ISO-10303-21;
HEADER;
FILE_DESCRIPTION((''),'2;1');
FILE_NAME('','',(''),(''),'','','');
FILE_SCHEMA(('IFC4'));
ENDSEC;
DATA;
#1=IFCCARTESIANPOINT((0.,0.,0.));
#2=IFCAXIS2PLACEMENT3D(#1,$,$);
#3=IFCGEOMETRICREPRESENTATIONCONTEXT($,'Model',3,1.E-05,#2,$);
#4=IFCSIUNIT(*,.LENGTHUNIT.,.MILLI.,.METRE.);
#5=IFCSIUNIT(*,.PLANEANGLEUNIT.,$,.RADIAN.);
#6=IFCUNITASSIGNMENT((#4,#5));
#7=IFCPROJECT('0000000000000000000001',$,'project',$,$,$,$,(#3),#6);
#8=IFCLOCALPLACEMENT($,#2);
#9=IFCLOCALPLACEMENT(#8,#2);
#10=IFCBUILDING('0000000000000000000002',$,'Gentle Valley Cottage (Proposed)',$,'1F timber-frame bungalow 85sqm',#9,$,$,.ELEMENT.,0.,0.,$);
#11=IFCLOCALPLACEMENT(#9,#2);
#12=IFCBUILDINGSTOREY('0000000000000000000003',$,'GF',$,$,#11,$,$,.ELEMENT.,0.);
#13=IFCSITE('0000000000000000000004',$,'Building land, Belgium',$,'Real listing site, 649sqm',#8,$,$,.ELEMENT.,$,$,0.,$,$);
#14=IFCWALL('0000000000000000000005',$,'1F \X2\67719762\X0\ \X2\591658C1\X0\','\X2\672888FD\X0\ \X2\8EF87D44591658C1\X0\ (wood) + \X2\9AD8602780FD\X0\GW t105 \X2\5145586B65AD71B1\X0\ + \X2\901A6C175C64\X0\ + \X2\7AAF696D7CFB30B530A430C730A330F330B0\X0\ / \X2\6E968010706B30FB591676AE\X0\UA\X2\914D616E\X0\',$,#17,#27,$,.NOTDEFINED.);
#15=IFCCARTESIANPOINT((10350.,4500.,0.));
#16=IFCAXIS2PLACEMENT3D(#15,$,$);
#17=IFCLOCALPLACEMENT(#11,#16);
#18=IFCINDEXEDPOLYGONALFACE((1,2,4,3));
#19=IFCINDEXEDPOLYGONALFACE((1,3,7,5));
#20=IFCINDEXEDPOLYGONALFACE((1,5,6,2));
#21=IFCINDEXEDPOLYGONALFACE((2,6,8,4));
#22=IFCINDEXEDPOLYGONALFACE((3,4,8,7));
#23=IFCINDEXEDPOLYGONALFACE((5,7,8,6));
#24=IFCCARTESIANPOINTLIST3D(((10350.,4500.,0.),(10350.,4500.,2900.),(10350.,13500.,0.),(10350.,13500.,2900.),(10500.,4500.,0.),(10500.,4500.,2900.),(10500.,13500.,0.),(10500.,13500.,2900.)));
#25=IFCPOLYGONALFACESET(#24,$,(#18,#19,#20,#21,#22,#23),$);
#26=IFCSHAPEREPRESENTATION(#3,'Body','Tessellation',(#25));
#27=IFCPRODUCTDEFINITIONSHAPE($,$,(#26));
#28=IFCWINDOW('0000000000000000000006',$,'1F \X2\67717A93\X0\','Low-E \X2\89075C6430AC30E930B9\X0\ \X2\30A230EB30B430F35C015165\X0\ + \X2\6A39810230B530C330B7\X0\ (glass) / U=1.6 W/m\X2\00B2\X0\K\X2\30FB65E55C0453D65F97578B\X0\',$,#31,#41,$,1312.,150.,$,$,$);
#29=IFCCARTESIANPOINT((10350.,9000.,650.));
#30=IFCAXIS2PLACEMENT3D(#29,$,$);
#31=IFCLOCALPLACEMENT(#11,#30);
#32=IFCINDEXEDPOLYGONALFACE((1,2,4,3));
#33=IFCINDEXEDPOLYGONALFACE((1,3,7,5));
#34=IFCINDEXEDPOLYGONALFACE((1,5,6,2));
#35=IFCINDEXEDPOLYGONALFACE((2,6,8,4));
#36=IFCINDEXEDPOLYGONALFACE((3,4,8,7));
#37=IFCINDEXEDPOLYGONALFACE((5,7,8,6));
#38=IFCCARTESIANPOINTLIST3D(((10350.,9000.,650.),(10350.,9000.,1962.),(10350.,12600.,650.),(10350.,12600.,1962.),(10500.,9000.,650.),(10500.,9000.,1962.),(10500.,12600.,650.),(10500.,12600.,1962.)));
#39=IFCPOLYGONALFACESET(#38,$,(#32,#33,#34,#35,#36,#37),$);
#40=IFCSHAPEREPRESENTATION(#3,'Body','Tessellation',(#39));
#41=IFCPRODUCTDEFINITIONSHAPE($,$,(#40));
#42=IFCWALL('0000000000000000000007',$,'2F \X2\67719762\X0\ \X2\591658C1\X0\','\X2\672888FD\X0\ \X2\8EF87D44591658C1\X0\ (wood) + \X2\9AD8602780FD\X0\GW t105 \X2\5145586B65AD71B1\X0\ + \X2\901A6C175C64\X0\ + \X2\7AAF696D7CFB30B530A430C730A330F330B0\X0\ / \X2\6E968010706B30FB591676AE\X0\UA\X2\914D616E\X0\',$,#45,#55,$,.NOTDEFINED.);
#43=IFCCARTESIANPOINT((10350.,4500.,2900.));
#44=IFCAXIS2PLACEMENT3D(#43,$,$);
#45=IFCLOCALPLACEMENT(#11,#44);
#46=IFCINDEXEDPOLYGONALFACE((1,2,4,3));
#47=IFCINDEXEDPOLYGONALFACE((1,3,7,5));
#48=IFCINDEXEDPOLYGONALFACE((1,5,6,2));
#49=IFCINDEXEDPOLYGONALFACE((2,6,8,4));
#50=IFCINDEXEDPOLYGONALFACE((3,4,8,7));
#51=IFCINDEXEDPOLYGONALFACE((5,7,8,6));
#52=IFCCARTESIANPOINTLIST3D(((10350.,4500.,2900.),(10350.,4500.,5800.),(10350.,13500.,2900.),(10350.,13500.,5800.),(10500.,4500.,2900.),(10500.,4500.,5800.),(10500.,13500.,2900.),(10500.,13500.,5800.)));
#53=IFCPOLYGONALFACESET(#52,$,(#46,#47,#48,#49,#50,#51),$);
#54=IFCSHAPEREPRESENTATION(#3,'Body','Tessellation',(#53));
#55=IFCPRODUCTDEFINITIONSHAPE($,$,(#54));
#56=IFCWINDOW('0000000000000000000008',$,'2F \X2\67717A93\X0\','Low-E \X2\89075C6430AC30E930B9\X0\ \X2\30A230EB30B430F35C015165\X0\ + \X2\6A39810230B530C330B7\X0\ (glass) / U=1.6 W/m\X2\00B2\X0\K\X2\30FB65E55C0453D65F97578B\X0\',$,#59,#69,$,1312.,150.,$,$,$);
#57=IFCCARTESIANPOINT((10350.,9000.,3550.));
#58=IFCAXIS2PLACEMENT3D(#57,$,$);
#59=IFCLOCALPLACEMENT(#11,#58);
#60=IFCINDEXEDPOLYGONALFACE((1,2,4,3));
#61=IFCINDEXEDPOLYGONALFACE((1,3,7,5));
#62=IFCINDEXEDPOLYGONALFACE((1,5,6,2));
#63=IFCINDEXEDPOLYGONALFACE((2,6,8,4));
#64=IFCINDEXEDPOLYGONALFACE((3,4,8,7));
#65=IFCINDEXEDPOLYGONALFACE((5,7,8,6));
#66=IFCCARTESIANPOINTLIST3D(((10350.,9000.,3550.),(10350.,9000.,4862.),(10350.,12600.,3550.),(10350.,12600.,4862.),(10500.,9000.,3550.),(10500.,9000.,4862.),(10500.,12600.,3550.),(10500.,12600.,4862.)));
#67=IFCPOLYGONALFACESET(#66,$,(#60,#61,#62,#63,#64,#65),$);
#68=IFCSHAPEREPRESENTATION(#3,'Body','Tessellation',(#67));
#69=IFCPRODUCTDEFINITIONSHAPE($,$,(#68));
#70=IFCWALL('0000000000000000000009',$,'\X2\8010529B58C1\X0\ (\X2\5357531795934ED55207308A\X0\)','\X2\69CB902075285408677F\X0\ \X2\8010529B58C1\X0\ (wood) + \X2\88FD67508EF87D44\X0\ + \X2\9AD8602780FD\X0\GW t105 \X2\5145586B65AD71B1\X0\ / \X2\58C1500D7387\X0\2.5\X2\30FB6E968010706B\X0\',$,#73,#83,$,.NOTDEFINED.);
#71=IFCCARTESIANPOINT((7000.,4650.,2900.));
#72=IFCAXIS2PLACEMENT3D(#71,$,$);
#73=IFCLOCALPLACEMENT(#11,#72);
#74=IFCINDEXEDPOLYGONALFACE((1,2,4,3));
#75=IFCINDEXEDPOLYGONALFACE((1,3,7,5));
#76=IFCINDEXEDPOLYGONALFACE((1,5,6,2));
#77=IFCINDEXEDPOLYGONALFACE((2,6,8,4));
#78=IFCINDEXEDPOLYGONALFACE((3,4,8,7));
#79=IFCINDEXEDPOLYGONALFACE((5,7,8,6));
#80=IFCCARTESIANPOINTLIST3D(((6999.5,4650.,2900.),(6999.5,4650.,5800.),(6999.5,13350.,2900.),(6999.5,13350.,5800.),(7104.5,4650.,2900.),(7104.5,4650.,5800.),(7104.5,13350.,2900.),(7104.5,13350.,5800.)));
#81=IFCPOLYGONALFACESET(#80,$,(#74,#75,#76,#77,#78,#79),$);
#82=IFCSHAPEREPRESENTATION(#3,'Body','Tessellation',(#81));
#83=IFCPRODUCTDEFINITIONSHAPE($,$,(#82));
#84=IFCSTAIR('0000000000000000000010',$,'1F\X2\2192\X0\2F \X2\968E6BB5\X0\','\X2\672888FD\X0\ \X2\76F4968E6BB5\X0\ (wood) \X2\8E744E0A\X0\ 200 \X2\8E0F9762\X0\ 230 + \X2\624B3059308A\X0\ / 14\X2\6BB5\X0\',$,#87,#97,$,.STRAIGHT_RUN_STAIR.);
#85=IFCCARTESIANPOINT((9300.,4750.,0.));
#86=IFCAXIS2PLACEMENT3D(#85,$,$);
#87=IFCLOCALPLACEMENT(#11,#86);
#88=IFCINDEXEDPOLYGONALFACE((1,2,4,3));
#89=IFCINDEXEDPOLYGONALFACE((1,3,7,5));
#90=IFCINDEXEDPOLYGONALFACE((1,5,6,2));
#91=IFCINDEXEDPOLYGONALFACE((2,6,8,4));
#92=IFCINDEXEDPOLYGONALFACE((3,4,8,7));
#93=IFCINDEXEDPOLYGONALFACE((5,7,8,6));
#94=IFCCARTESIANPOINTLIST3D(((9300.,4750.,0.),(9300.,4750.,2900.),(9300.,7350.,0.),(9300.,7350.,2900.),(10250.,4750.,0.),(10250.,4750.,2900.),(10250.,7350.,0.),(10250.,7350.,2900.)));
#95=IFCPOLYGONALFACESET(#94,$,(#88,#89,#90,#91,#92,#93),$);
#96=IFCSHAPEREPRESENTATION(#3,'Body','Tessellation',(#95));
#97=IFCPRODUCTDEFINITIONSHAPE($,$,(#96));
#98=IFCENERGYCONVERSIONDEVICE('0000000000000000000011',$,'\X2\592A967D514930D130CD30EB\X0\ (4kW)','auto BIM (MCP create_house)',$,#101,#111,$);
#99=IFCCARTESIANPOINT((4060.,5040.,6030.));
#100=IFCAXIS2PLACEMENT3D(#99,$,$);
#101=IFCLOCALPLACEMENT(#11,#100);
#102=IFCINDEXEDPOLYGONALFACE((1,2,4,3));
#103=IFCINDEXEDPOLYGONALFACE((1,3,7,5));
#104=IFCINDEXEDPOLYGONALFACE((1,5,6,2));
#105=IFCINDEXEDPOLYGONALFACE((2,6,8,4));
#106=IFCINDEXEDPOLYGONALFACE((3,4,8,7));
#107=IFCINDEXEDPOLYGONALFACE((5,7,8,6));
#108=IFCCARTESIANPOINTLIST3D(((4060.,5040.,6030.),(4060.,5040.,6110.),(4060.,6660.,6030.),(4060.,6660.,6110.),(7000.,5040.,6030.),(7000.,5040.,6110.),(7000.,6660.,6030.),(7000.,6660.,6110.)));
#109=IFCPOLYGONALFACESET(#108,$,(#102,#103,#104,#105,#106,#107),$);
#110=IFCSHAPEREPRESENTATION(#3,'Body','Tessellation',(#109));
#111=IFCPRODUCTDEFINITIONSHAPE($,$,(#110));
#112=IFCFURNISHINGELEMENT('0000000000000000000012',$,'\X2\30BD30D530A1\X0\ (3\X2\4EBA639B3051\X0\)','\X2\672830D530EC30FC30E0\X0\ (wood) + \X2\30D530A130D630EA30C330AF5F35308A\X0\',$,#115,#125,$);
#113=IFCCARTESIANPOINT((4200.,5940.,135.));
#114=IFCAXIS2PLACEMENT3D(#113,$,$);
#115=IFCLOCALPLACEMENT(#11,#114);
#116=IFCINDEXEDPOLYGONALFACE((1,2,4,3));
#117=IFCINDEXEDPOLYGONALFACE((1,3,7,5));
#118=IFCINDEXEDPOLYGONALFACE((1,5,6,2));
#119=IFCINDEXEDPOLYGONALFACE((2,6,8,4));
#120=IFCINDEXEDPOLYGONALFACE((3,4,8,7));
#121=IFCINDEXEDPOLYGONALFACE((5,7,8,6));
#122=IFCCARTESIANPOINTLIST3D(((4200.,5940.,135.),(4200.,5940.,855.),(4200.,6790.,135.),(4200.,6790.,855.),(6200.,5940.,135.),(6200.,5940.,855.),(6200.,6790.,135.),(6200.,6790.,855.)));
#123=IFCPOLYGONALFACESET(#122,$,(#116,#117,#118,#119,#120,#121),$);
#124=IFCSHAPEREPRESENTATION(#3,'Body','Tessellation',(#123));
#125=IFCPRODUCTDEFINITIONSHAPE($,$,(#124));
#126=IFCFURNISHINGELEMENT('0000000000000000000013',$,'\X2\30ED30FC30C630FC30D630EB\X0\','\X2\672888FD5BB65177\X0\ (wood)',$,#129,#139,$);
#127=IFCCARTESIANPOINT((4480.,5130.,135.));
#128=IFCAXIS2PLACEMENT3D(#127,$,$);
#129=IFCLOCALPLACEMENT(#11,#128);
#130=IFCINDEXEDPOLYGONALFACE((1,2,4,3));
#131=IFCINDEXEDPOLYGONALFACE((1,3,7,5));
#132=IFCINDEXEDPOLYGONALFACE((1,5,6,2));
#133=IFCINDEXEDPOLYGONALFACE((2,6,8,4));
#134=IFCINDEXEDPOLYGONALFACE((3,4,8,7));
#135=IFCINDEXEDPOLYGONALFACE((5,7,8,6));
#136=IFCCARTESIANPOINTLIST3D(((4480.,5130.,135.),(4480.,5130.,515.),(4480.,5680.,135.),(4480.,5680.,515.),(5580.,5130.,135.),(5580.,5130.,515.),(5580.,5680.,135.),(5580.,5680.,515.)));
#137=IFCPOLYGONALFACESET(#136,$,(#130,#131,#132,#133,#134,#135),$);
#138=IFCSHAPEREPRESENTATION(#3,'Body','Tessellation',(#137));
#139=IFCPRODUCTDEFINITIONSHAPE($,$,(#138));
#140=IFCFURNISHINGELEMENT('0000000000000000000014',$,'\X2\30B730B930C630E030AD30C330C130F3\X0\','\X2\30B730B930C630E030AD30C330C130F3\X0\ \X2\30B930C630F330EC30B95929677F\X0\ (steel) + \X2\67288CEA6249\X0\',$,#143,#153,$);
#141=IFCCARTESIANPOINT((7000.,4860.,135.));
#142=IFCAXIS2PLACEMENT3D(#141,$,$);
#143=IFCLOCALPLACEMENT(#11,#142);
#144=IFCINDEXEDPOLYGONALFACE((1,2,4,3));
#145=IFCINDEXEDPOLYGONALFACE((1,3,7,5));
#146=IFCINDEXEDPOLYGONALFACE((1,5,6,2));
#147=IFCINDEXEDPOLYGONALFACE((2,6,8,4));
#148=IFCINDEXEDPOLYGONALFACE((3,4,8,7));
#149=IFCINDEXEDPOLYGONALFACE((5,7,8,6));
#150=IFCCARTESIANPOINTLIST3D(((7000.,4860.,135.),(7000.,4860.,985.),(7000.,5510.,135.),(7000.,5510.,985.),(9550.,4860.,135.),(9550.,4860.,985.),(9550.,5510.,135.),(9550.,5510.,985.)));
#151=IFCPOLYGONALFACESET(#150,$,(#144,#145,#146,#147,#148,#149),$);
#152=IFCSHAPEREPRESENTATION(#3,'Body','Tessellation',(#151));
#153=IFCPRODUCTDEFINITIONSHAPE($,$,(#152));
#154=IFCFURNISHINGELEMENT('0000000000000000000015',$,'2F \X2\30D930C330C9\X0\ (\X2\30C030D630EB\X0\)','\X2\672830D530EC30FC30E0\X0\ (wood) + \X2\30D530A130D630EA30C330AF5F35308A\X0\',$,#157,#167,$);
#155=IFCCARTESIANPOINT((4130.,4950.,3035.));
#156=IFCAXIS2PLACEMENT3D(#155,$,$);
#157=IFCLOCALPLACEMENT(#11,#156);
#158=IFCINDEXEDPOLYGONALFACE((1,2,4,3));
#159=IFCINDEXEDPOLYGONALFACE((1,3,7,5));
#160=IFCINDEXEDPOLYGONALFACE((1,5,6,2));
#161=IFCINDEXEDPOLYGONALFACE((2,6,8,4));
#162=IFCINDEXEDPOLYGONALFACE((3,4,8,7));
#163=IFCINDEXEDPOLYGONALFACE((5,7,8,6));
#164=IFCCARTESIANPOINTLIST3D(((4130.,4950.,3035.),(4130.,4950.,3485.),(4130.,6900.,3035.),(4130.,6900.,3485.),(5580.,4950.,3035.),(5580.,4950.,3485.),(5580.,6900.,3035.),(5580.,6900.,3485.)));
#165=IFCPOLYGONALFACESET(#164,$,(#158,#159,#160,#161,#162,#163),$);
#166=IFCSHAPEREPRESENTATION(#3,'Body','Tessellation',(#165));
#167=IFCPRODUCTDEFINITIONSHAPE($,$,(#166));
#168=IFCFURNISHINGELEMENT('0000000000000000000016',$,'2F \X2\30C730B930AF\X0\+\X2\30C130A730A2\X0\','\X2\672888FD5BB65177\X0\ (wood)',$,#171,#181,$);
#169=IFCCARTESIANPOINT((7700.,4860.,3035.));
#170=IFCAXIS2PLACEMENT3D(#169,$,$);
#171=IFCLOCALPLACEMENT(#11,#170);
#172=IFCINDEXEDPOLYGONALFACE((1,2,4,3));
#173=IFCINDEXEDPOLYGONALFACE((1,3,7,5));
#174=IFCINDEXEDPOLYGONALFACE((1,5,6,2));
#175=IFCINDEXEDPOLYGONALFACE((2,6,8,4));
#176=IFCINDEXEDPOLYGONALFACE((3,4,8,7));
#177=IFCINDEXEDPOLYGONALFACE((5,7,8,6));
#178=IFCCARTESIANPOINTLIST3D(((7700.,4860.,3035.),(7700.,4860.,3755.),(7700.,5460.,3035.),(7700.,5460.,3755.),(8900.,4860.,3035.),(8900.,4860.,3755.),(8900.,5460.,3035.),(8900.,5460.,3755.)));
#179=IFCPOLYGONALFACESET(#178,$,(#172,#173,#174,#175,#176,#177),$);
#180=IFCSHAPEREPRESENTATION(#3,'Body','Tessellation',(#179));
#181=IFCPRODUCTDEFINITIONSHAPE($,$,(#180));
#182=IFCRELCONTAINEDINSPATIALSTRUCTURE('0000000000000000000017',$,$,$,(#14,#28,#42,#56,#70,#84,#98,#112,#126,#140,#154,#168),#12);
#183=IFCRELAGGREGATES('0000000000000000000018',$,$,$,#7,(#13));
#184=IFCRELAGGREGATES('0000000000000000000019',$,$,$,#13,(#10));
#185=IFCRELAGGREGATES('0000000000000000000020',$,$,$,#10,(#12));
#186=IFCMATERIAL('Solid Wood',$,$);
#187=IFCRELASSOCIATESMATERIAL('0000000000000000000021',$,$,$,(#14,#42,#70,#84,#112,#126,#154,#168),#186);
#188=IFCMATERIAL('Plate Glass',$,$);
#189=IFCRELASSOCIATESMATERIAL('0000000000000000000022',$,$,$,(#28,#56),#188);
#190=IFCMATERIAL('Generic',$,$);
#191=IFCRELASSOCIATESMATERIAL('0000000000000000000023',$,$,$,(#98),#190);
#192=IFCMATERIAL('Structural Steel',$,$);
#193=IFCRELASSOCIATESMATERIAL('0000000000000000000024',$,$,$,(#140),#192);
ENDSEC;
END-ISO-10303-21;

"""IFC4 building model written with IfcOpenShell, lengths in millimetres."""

from ifc_helpers import new_model, si_unit, frame, frame_2d, origin, place, context, project, spatial, rectangle, extrude, material, element, fill, save


model = new_model("IFC4")

# Units and contexts
model_context = context("Model", 3, precision=1e-05, world=origin())
ifc_project = project(units=[si_unit("LENGTHUNIT", "METRE", prefix="MILLI"), si_unit("PLANEANGLEUNIT", "RADIAN")], contexts=[model_context])

# Site, building, storey
site_placement = place(None, origin())
site = spatial("IfcSite", under=ifc_project, at=site_placement, Name="Building land, Belgium", ObjectType="Real listing site, 649sqm", CompositionType="ELEMENT", RefElevation=0.0)
building_placement = place(site_placement, origin())
building = spatial("IfcBuilding", under=site, at=building_placement, Name="Gentle Valley Cottage (Proposed)", ObjectType="1F timber-frame bungalow 85sqm", CompositionType="ELEMENT", ElevationOfRefHeight=0.0, ElevationOfTerrain=0.0)
storey_placement = place(building_placement, origin())
storey = spatial("IfcBuildingStorey", under=building, at=storey_placement, Name="GF", CompositionType="ELEMENT", Elevation=0.0)

# Wall, opening, window
ifc_material_1 = material(Name="Solid Wood")
wall_1_placement = place(storey_placement, frame((10350.0, 4500.0, 0.0)))
wall_1 = element("IfcWall", 1, at=wall_1_placement, inside=storey, material=ifc_material_1, Name="1F 東面 外壁", Description="木製 軸組外壁 (wood) + 高性能GW t105 充填断熱 + 通気層 + 窯業系サイディング / 準耐火・外皮UA配慮", PredefinedType="NOTDEFINED", context=model_context, shape_type="SweptSolid", body=[
    extrude(rectangle(XDim=150.0, YDim=9000.0, at=frame_2d((75.0, 4500.0))), frame((10350.0, 4500.0, 0.0)), (0.0, 0.0, 1.0), 2900.0),
])
opening_1_placement = place(storey_placement, frame((10350.0, 9000.0, 650.0)))
opening_1 = element("IfcOpeningElement", 2, at=opening_1_placement, cuts=wall_1, PredefinedType="NOTDEFINED", context=model_context, shape_type="SweptSolid", body=[
    extrude(rectangle(XDim=150.0, YDim=3600.0, at=frame_2d((75.0, 1800.0))), frame((10350.0, 9000.0, 650.0)), (0.0, 0.0, 1.0), 1312.0),
])
ifc_material_2 = material(Name="Plate Glass")
window_1_placement = place(storey_placement, frame((10350.0, 9000.0, 650.0)))
window_1 = element("IfcWindow", 3, at=window_1_placement, inside=storey, material=ifc_material_2, Name="1F 東窓", Description="Low-E 複層ガラス アルゴン封入 + 樹脂サッシ (glass) / U=1.6 W/m²K・日射取得型", OverallHeight=1312.0, OverallWidth=150.0, context=model_context, shape_type="SweptSolid", body=[
    extrude(rectangle(XDim=150.0, YDim=3600.0, at=frame_2d((75.0, 1800.0))), frame((10350.0, 9000.0, 650.0)), (0.0, 0.0, 1.0), 1312.0),
])
fill(opening_1, window_1)

# Wall, opening, window
wall_2_placement = place(storey_placement, frame((10350.0, 4500.0, 2900.0)))
wall_2 = element("IfcWall", 4, at=wall_2_placement, inside=storey, material=ifc_material_1, Name="2F 東面 外壁", Description="木製 軸組外壁 (wood) + 高性能GW t105 充填断熱 + 通気層 + 窯業系サイディング / 準耐火・外皮UA配慮", PredefinedType="NOTDEFINED", context=model_context, shape_type="SweptSolid", body=[
    extrude(rectangle(XDim=150.0, YDim=9000.0, at=frame_2d((75.0, 4500.0))), frame((10350.0, 4500.0, 2900.0)), (0.0, 0.0, 1.0), 2900.0),
])
opening_2_placement = place(storey_placement, frame((10350.0, 9000.0, 3550.0)))
opening_2 = element("IfcOpeningElement", 5, at=opening_2_placement, cuts=wall_2, PredefinedType="NOTDEFINED", context=model_context, shape_type="SweptSolid", body=[
    extrude(rectangle(XDim=150.0, YDim=3600.0, at=frame_2d((75.0, 1800.0))), frame((10350.0, 9000.0, 3550.0)), (0.0, 0.0, 1.0), 1312.0),
])
window_2_placement = place(storey_placement, frame((10350.0, 9000.0, 3550.0)))
window_2 = element("IfcWindow", 6, at=window_2_placement, inside=storey, material=ifc_material_2, Name="2F 東窓", Description="Low-E 複層ガラス アルゴン封入 + 樹脂サッシ (glass) / U=1.6 W/m²K・日射取得型", OverallHeight=1312.0, OverallWidth=150.0, context=model_context, shape_type="SweptSolid", body=[
    extrude(rectangle(XDim=150.0, YDim=3600.0, at=frame_2d((75.0, 1800.0))), frame((10350.0, 9000.0, 3550.0)), (0.0, 0.0, 1.0), 1312.0),
])
fill(opening_2, window_2)

# Wall
wall_3_placement = place(storey_placement, frame((7000.0, 4650.0, 2900.0)))
element("IfcWall", 7, at=wall_3_placement, inside=storey, material=ifc_material_1, Name="耐力壁 (南北間仕切り)", Description="構造用合板 耐力壁 (wood) + 製材軸組 + 高性能GW t105 充填断熱 / 壁倍率2.5・準耐火", PredefinedType="NOTDEFINED", context=model_context, shape_type="SweptSolid", body=[
    extrude(rectangle(XDim=105.0, YDim=8700.0, at=frame_2d((52.0, 4350.0))), frame((7000.0, 4650.0, 2900.0)), (0.0, 0.0, 1.0), 2900.0),
])

# Stair
stair_placement = place(storey_placement, frame((9300.0, 4750.0, 0.0)))
element("IfcStair", 8, at=stair_placement, inside=storey, material=ifc_material_1, Name="1F→2F 階段", Description="木製 直階段 (wood) 蹴上 200 踏面 230 + 手すり / 14段", PredefinedType="STRAIGHT_RUN_STAIR", context=model_context, shape_type="SweptSolid", body=[
    extrude(rectangle(XDim=950.0, YDim=2600.0, at=frame_2d((475.0, 1300.0))), frame((9300.0, 4750.0, 0.0)), (0.0, 0.0, 1.0), 2900.0),
])

# Energy conversion device
ifc_material_3 = material(Name="Generic")
energy_conversion_device_placement = place(storey_placement, frame((4060.0, 5040.0, 6030.0)))
element("IfcEnergyConversionDevice", 9, at=energy_conversion_device_placement, inside=storey, material=ifc_material_3, Name="太陽光パネル (4kW)", Description="auto BIM (MCP create_house)", context=model_context, shape_type="SweptSolid", body=[
    extrude(rectangle(XDim=2940.0, YDim=1620.0, at=frame_2d((1470.0, 810.0))), frame((4060.0, 5040.0, 6030.0)), (0.0, 0.0, 1.0), 80.0),
])

# Furnishing elements
furnishing_1_placement = place(storey_placement, frame((4200.0, 5940.0, 135.0)))
element("IfcFurnishingElement", 10, at=furnishing_1_placement, inside=storey, material=ifc_material_1, Name="ソファ (3人掛け)", Description="木フレーム (wood) + ファブリック張り", context=model_context, shape_type="SweptSolid", body=[
    extrude(rectangle(XDim=2000.0, YDim=850.0, at=frame_2d((1000.0, 425.0))), frame((4200.0, 5940.0, 135.0)), (0.0, 0.0, 1.0), 720.0),
])
furnishing_2_placement = place(storey_placement, frame((4480.0, 5130.0, 135.0)))
element("IfcFurnishingElement", 11, at=furnishing_2_placement, inside=storey, material=ifc_material_1, Name="ローテーブル", Description="木製家具 (wood)", context=model_context, shape_type="SweptSolid", body=[
    extrude(rectangle(XDim=1100.0, YDim=550.0, at=frame_2d((550.0, 275.0))), frame((4480.0, 5130.0, 135.0)), (0.0, 0.0, 1.0), 380.0),
])
ifc_material_4 = material(Name="Structural Steel")
furnishing_3_placement = place(storey_placement, frame((7000.0, 4860.0, 135.0)))
element("IfcFurnishingElement", 12, at=furnishing_3_placement, inside=storey, material=ifc_material_4, Name="システムキッチン", Description="システムキッチン ステンレス天板 (steel) + 木質扉", context=model_context, shape_type="SweptSolid", body=[
    extrude(rectangle(XDim=2550.0, YDim=650.0, at=frame_2d((1275.0, 325.0))), frame((7000.0, 4860.0, 135.0)), (0.0, 0.0, 1.0), 850.0),
])
furnishing_4_placement = place(storey_placement, frame((4130.0, 4950.0, 3035.0)))
element("IfcFurnishingElement", 13, at=furnishing_4_placement, inside=storey, material=ifc_material_1, Name="2F ベッド (ダブル)", Description="木フレーム (wood) + ファブリック張り", context=model_context, shape_type="SweptSolid", body=[
    extrude(rectangle(XDim=1450.0, YDim=1950.0, at=frame_2d((725.0, 975.0))), frame((4130.0, 4950.0, 3035.0)), (0.0, 0.0, 1.0), 450.0),
])
furnishing_5_placement = place(storey_placement, frame((7700.0, 4860.0, 3035.0)))
element("IfcFurnishingElement", 14, at=furnishing_5_placement, inside=storey, material=ifc_material_1, Name="2F デスク+チェア", Description="木製家具 (wood)", context=model_context, shape_type="SweptSolid", body=[
    extrude(rectangle(XDim=1200.0, YDim=600.0, at=frame_2d((600.0, 300.0))), frame((7700.0, 4860.0, 3035.0)), (0.0, 0.0, 1.0), 720.0),
])

save(model, "model.ifc")
